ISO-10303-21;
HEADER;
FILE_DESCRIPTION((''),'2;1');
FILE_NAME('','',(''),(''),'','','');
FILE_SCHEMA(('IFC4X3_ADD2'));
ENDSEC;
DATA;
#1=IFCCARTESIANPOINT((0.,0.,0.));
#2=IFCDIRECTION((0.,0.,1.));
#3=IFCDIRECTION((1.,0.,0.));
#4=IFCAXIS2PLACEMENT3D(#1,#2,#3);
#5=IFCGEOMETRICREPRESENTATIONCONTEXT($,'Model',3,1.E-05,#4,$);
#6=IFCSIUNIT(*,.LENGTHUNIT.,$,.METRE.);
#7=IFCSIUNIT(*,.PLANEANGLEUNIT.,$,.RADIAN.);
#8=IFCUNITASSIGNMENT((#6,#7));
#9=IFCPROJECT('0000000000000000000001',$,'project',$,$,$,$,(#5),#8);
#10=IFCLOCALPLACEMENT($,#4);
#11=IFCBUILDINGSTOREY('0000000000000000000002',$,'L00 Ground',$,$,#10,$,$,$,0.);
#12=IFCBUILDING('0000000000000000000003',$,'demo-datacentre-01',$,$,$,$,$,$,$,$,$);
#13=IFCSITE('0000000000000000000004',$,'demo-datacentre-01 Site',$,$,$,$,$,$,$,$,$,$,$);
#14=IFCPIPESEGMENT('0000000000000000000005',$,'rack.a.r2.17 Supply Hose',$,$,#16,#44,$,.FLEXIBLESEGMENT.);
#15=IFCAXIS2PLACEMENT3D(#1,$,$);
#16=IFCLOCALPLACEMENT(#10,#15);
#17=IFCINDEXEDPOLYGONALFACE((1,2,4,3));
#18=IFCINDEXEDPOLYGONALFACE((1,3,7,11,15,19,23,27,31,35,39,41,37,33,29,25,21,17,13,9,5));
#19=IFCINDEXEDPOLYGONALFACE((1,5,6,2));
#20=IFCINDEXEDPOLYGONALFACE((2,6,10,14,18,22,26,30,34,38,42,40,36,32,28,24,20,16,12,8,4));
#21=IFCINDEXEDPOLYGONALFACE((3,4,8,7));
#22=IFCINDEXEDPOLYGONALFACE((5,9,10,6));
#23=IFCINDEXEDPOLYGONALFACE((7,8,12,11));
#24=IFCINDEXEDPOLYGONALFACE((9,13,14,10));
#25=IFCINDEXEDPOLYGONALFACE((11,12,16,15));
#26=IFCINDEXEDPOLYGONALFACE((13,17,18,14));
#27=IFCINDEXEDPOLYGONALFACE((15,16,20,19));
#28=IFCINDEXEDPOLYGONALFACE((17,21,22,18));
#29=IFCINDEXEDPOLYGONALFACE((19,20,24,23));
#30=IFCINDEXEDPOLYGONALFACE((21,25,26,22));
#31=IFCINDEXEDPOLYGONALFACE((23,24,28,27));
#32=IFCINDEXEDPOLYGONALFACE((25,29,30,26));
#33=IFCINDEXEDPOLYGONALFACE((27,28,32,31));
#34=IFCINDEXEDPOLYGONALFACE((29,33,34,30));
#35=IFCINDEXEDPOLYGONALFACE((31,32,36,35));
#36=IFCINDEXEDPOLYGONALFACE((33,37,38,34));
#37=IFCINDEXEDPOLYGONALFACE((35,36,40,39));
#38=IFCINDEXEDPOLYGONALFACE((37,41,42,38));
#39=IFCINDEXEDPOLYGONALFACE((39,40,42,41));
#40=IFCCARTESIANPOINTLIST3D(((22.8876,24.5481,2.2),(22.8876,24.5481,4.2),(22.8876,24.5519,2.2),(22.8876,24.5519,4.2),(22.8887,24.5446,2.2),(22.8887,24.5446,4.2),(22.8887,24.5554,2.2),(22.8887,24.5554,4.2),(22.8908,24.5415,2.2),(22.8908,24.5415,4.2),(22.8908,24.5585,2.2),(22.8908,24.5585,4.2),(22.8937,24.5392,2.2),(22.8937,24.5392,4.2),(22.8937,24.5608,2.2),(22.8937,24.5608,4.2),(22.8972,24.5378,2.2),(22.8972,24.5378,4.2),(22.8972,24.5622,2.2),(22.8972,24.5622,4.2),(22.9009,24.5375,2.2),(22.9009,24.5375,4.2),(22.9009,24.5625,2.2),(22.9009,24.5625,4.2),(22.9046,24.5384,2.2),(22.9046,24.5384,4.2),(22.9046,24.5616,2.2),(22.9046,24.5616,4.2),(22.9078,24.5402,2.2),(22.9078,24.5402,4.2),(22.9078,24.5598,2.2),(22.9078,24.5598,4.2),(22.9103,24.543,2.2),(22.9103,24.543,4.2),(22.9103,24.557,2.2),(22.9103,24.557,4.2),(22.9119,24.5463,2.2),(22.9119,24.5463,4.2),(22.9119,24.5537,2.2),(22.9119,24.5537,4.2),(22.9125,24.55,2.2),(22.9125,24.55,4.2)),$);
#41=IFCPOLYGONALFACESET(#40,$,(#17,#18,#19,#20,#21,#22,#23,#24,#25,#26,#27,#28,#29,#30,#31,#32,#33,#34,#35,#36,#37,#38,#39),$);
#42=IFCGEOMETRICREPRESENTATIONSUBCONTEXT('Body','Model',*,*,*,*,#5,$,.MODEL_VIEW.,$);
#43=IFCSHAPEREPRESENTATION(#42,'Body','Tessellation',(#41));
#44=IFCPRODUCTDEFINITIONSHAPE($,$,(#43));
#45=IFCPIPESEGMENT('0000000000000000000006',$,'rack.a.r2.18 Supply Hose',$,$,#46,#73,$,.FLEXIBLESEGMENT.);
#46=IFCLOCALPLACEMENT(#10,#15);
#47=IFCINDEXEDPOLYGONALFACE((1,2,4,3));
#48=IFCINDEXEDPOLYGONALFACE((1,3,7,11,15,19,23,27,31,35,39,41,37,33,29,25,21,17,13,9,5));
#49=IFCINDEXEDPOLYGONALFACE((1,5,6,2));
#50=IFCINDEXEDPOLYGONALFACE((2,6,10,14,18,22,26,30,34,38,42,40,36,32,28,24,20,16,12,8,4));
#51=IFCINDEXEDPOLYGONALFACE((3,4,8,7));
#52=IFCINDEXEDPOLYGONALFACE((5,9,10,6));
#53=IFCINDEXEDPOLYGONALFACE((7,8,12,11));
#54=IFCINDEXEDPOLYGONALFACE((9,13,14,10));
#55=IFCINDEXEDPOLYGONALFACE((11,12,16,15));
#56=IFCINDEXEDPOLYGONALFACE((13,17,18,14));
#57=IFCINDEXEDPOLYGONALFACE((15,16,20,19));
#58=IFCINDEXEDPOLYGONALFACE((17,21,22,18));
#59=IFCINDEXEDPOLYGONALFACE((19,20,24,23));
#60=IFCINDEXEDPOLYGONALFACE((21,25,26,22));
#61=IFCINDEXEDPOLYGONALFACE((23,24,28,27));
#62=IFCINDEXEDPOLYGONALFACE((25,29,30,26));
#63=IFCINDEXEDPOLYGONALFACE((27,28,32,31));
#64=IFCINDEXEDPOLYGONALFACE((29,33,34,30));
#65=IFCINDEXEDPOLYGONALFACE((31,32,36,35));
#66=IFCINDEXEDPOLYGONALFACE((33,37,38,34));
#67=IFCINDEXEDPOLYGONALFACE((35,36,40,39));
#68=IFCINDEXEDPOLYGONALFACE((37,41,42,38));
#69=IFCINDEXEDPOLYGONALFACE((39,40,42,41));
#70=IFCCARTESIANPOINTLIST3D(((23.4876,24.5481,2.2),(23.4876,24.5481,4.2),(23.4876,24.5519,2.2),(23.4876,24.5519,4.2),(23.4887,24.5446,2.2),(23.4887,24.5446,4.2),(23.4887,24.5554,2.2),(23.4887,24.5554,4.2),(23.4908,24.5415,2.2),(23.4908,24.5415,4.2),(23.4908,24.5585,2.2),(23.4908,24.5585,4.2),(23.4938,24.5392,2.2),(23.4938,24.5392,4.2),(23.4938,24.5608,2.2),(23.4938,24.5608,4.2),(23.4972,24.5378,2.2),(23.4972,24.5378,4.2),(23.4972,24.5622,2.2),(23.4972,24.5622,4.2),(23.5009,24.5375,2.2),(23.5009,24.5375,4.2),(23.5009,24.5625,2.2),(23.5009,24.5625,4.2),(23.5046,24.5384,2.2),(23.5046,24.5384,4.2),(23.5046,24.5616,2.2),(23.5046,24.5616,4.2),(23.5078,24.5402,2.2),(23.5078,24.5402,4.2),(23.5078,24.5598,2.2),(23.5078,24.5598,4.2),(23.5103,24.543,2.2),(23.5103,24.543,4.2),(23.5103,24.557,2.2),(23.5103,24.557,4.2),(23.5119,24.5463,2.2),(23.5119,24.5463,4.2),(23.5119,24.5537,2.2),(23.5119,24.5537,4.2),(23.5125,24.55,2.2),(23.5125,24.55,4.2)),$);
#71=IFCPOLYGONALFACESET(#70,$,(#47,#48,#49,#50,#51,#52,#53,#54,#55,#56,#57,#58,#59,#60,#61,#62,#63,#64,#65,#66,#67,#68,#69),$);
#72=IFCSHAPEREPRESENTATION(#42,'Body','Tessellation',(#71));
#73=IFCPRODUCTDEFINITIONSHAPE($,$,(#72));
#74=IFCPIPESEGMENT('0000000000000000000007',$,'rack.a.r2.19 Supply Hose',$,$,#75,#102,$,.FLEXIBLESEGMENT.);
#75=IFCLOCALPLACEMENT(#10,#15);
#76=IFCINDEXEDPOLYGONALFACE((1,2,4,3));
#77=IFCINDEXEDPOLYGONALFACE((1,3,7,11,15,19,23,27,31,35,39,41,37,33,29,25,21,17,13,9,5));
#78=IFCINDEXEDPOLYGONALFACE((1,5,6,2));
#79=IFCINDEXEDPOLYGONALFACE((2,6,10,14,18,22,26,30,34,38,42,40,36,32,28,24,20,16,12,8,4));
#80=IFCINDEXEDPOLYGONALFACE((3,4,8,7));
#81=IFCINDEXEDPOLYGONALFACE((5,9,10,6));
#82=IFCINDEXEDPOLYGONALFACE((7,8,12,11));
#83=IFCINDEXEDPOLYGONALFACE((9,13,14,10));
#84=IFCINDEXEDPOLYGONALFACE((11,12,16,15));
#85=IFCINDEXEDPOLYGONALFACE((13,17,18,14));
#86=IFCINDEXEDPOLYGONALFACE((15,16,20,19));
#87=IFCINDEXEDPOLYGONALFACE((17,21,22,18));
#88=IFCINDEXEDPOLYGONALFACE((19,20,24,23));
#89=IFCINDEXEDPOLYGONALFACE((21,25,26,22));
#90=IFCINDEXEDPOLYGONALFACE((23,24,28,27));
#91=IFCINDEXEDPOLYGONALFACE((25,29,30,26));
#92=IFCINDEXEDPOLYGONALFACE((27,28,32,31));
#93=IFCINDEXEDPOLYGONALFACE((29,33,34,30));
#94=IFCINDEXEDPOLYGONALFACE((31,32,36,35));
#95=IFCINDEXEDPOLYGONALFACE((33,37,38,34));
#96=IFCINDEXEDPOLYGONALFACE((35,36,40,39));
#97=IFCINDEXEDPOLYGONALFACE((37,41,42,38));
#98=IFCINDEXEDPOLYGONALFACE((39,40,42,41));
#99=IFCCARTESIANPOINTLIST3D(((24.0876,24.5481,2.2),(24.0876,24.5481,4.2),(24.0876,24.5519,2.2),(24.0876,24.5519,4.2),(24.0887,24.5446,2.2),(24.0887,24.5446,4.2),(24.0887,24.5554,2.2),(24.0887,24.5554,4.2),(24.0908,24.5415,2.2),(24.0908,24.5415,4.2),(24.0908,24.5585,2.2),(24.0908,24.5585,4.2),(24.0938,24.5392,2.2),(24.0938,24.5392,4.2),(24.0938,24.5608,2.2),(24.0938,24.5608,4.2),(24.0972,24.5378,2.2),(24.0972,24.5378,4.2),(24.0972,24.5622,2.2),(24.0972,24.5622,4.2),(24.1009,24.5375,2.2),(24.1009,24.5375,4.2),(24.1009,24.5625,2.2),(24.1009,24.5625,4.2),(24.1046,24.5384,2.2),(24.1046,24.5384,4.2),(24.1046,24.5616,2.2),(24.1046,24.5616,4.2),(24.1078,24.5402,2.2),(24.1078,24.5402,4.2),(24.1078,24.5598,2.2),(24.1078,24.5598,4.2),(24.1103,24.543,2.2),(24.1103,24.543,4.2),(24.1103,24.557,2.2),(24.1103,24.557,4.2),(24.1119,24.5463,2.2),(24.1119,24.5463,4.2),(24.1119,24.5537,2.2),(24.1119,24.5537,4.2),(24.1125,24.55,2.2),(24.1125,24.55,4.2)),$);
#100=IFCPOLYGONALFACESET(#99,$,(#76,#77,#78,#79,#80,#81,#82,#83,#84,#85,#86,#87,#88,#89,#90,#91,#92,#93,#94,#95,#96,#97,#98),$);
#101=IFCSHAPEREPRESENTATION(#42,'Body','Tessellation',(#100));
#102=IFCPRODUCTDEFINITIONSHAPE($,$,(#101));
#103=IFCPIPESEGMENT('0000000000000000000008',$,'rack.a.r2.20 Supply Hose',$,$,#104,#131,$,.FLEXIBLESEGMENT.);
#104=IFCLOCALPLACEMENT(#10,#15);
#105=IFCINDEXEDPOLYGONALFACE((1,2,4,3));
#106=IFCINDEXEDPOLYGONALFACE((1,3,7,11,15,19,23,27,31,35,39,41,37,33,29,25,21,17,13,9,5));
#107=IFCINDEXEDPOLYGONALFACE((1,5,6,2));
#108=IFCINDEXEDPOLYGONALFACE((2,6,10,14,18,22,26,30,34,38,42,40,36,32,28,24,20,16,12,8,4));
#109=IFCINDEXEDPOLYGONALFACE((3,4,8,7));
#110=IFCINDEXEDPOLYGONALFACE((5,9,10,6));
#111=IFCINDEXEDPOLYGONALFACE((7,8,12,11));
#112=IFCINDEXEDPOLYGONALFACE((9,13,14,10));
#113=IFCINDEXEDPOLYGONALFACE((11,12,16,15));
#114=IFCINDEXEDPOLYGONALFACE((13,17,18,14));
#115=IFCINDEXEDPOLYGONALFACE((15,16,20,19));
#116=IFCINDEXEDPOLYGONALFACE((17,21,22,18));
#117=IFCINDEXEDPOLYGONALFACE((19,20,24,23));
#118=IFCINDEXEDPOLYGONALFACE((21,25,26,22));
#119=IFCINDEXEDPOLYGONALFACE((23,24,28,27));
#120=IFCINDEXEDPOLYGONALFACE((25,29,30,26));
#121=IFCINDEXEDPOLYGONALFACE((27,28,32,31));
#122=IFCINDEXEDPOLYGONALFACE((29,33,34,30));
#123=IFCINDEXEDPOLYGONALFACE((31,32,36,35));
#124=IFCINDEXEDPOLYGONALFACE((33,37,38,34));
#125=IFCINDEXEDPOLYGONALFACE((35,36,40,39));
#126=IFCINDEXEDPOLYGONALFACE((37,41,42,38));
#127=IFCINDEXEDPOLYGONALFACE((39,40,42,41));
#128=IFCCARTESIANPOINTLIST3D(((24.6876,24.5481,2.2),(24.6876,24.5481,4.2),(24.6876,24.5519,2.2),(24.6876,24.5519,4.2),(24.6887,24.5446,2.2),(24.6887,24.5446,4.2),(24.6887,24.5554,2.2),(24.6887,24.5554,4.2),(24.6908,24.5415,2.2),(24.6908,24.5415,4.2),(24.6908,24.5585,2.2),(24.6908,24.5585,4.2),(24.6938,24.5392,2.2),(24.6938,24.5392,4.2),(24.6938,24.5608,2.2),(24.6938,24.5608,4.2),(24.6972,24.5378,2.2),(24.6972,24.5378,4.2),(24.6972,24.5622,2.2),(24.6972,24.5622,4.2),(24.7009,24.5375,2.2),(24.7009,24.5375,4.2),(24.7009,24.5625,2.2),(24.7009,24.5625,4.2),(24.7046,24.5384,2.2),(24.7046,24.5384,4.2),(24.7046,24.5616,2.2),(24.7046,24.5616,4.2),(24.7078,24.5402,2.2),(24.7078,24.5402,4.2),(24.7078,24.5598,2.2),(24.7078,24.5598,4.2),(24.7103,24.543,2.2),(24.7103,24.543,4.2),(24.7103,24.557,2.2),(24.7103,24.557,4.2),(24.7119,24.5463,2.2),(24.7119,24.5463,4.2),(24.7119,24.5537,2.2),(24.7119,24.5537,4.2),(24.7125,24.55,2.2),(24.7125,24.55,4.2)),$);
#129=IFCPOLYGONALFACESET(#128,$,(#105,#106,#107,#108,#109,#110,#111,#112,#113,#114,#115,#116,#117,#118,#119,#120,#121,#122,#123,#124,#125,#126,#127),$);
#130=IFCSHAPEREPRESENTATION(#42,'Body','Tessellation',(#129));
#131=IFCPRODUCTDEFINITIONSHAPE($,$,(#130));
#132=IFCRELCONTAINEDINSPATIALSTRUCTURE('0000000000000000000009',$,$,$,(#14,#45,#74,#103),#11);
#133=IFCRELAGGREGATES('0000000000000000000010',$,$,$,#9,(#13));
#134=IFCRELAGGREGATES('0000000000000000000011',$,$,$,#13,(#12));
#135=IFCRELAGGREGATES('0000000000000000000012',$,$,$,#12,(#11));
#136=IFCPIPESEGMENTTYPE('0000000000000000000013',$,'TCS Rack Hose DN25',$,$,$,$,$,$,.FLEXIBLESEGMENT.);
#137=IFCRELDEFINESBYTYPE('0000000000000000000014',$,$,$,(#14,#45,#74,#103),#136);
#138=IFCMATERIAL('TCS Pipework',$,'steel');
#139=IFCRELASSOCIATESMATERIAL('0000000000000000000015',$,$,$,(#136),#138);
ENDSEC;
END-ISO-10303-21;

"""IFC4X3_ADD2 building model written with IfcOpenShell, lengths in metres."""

from ifc_helpers import new_model, si_unit, frame, origin_with_axes, place, context, subcontext, project, spatial, circle, extrude, material, type_object, element, save


model = new_model("IFC4X3_ADD2")

# Units and contexts
model_context = context("Model", 3, precision=1e-05, world=origin_with_axes())
body_context = subcontext(model_context, "Body", "Model", "MODEL_VIEW")
ifc_project = project(units=[si_unit("LENGTHUNIT", "METRE"), si_unit("PLANEANGLEUNIT", "RADIAN")], contexts=[model_context])

# Site, building, storey
site = spatial("IfcSite", under=ifc_project, Name="demo-datacentre-01 Site")
building = spatial("IfcBuilding", under=site, Name="demo-datacentre-01")
storey_placement = place(None, origin_with_axes())
storey = spatial("IfcBuildingStorey", under=building, at=storey_placement, Name="L00 Ground", Elevation=0.0)

# Shared definitions
ifc_material = material(Name="TCS Pipework", Category="steel")

# Pipe segments
pipe_segment_type_1 = type_object("IfcPipeSegmentType", Name="TCS Rack Hose DN25", PredefinedType="FLEXIBLESEGMENT", material=ifc_material)
for number, where, z_axis, x_axis, name in (
    (1, (22.9, 24.55, 4.2), (0.0, 0.0, -1.0), (1.0, 0.0, 0.0), "rack.a.r2.17 Supply Hose"),
    (2, (23.5, 24.55, 4.2), (0.0, 0.0, -1.0), (1.0, 0.0, 0.0), "rack.a.r2.18 Supply Hose"),
    (3, (24.1, 24.55, 4.2), (0.0, 0.0, -1.0), (1.0, 0.0, 0.0), "rack.a.r2.19 Supply Hose"),
    (4, (24.7, 24.55, 4.2), (0.0, 0.0, -1.0), (1.0, 0.0, 0.0), "rack.a.r2.20 Supply Hose"),
):
    element("IfcPipeSegment", number, at=place(storey_placement, frame(where, z_axis=z_axis, x_axis=x_axis)), inside=storey, type_object=pipe_segment_type_1, Name=name, PredefinedType="FLEXIBLESEGMENT", context=body_context, shape_type="SweptSolid", body=[
        extrude(circle(Radius=0.0125), origin_with_axes(), (0.0, 0.0, 1.0), 2.0),
    ])

save(model, "model.ifc")
